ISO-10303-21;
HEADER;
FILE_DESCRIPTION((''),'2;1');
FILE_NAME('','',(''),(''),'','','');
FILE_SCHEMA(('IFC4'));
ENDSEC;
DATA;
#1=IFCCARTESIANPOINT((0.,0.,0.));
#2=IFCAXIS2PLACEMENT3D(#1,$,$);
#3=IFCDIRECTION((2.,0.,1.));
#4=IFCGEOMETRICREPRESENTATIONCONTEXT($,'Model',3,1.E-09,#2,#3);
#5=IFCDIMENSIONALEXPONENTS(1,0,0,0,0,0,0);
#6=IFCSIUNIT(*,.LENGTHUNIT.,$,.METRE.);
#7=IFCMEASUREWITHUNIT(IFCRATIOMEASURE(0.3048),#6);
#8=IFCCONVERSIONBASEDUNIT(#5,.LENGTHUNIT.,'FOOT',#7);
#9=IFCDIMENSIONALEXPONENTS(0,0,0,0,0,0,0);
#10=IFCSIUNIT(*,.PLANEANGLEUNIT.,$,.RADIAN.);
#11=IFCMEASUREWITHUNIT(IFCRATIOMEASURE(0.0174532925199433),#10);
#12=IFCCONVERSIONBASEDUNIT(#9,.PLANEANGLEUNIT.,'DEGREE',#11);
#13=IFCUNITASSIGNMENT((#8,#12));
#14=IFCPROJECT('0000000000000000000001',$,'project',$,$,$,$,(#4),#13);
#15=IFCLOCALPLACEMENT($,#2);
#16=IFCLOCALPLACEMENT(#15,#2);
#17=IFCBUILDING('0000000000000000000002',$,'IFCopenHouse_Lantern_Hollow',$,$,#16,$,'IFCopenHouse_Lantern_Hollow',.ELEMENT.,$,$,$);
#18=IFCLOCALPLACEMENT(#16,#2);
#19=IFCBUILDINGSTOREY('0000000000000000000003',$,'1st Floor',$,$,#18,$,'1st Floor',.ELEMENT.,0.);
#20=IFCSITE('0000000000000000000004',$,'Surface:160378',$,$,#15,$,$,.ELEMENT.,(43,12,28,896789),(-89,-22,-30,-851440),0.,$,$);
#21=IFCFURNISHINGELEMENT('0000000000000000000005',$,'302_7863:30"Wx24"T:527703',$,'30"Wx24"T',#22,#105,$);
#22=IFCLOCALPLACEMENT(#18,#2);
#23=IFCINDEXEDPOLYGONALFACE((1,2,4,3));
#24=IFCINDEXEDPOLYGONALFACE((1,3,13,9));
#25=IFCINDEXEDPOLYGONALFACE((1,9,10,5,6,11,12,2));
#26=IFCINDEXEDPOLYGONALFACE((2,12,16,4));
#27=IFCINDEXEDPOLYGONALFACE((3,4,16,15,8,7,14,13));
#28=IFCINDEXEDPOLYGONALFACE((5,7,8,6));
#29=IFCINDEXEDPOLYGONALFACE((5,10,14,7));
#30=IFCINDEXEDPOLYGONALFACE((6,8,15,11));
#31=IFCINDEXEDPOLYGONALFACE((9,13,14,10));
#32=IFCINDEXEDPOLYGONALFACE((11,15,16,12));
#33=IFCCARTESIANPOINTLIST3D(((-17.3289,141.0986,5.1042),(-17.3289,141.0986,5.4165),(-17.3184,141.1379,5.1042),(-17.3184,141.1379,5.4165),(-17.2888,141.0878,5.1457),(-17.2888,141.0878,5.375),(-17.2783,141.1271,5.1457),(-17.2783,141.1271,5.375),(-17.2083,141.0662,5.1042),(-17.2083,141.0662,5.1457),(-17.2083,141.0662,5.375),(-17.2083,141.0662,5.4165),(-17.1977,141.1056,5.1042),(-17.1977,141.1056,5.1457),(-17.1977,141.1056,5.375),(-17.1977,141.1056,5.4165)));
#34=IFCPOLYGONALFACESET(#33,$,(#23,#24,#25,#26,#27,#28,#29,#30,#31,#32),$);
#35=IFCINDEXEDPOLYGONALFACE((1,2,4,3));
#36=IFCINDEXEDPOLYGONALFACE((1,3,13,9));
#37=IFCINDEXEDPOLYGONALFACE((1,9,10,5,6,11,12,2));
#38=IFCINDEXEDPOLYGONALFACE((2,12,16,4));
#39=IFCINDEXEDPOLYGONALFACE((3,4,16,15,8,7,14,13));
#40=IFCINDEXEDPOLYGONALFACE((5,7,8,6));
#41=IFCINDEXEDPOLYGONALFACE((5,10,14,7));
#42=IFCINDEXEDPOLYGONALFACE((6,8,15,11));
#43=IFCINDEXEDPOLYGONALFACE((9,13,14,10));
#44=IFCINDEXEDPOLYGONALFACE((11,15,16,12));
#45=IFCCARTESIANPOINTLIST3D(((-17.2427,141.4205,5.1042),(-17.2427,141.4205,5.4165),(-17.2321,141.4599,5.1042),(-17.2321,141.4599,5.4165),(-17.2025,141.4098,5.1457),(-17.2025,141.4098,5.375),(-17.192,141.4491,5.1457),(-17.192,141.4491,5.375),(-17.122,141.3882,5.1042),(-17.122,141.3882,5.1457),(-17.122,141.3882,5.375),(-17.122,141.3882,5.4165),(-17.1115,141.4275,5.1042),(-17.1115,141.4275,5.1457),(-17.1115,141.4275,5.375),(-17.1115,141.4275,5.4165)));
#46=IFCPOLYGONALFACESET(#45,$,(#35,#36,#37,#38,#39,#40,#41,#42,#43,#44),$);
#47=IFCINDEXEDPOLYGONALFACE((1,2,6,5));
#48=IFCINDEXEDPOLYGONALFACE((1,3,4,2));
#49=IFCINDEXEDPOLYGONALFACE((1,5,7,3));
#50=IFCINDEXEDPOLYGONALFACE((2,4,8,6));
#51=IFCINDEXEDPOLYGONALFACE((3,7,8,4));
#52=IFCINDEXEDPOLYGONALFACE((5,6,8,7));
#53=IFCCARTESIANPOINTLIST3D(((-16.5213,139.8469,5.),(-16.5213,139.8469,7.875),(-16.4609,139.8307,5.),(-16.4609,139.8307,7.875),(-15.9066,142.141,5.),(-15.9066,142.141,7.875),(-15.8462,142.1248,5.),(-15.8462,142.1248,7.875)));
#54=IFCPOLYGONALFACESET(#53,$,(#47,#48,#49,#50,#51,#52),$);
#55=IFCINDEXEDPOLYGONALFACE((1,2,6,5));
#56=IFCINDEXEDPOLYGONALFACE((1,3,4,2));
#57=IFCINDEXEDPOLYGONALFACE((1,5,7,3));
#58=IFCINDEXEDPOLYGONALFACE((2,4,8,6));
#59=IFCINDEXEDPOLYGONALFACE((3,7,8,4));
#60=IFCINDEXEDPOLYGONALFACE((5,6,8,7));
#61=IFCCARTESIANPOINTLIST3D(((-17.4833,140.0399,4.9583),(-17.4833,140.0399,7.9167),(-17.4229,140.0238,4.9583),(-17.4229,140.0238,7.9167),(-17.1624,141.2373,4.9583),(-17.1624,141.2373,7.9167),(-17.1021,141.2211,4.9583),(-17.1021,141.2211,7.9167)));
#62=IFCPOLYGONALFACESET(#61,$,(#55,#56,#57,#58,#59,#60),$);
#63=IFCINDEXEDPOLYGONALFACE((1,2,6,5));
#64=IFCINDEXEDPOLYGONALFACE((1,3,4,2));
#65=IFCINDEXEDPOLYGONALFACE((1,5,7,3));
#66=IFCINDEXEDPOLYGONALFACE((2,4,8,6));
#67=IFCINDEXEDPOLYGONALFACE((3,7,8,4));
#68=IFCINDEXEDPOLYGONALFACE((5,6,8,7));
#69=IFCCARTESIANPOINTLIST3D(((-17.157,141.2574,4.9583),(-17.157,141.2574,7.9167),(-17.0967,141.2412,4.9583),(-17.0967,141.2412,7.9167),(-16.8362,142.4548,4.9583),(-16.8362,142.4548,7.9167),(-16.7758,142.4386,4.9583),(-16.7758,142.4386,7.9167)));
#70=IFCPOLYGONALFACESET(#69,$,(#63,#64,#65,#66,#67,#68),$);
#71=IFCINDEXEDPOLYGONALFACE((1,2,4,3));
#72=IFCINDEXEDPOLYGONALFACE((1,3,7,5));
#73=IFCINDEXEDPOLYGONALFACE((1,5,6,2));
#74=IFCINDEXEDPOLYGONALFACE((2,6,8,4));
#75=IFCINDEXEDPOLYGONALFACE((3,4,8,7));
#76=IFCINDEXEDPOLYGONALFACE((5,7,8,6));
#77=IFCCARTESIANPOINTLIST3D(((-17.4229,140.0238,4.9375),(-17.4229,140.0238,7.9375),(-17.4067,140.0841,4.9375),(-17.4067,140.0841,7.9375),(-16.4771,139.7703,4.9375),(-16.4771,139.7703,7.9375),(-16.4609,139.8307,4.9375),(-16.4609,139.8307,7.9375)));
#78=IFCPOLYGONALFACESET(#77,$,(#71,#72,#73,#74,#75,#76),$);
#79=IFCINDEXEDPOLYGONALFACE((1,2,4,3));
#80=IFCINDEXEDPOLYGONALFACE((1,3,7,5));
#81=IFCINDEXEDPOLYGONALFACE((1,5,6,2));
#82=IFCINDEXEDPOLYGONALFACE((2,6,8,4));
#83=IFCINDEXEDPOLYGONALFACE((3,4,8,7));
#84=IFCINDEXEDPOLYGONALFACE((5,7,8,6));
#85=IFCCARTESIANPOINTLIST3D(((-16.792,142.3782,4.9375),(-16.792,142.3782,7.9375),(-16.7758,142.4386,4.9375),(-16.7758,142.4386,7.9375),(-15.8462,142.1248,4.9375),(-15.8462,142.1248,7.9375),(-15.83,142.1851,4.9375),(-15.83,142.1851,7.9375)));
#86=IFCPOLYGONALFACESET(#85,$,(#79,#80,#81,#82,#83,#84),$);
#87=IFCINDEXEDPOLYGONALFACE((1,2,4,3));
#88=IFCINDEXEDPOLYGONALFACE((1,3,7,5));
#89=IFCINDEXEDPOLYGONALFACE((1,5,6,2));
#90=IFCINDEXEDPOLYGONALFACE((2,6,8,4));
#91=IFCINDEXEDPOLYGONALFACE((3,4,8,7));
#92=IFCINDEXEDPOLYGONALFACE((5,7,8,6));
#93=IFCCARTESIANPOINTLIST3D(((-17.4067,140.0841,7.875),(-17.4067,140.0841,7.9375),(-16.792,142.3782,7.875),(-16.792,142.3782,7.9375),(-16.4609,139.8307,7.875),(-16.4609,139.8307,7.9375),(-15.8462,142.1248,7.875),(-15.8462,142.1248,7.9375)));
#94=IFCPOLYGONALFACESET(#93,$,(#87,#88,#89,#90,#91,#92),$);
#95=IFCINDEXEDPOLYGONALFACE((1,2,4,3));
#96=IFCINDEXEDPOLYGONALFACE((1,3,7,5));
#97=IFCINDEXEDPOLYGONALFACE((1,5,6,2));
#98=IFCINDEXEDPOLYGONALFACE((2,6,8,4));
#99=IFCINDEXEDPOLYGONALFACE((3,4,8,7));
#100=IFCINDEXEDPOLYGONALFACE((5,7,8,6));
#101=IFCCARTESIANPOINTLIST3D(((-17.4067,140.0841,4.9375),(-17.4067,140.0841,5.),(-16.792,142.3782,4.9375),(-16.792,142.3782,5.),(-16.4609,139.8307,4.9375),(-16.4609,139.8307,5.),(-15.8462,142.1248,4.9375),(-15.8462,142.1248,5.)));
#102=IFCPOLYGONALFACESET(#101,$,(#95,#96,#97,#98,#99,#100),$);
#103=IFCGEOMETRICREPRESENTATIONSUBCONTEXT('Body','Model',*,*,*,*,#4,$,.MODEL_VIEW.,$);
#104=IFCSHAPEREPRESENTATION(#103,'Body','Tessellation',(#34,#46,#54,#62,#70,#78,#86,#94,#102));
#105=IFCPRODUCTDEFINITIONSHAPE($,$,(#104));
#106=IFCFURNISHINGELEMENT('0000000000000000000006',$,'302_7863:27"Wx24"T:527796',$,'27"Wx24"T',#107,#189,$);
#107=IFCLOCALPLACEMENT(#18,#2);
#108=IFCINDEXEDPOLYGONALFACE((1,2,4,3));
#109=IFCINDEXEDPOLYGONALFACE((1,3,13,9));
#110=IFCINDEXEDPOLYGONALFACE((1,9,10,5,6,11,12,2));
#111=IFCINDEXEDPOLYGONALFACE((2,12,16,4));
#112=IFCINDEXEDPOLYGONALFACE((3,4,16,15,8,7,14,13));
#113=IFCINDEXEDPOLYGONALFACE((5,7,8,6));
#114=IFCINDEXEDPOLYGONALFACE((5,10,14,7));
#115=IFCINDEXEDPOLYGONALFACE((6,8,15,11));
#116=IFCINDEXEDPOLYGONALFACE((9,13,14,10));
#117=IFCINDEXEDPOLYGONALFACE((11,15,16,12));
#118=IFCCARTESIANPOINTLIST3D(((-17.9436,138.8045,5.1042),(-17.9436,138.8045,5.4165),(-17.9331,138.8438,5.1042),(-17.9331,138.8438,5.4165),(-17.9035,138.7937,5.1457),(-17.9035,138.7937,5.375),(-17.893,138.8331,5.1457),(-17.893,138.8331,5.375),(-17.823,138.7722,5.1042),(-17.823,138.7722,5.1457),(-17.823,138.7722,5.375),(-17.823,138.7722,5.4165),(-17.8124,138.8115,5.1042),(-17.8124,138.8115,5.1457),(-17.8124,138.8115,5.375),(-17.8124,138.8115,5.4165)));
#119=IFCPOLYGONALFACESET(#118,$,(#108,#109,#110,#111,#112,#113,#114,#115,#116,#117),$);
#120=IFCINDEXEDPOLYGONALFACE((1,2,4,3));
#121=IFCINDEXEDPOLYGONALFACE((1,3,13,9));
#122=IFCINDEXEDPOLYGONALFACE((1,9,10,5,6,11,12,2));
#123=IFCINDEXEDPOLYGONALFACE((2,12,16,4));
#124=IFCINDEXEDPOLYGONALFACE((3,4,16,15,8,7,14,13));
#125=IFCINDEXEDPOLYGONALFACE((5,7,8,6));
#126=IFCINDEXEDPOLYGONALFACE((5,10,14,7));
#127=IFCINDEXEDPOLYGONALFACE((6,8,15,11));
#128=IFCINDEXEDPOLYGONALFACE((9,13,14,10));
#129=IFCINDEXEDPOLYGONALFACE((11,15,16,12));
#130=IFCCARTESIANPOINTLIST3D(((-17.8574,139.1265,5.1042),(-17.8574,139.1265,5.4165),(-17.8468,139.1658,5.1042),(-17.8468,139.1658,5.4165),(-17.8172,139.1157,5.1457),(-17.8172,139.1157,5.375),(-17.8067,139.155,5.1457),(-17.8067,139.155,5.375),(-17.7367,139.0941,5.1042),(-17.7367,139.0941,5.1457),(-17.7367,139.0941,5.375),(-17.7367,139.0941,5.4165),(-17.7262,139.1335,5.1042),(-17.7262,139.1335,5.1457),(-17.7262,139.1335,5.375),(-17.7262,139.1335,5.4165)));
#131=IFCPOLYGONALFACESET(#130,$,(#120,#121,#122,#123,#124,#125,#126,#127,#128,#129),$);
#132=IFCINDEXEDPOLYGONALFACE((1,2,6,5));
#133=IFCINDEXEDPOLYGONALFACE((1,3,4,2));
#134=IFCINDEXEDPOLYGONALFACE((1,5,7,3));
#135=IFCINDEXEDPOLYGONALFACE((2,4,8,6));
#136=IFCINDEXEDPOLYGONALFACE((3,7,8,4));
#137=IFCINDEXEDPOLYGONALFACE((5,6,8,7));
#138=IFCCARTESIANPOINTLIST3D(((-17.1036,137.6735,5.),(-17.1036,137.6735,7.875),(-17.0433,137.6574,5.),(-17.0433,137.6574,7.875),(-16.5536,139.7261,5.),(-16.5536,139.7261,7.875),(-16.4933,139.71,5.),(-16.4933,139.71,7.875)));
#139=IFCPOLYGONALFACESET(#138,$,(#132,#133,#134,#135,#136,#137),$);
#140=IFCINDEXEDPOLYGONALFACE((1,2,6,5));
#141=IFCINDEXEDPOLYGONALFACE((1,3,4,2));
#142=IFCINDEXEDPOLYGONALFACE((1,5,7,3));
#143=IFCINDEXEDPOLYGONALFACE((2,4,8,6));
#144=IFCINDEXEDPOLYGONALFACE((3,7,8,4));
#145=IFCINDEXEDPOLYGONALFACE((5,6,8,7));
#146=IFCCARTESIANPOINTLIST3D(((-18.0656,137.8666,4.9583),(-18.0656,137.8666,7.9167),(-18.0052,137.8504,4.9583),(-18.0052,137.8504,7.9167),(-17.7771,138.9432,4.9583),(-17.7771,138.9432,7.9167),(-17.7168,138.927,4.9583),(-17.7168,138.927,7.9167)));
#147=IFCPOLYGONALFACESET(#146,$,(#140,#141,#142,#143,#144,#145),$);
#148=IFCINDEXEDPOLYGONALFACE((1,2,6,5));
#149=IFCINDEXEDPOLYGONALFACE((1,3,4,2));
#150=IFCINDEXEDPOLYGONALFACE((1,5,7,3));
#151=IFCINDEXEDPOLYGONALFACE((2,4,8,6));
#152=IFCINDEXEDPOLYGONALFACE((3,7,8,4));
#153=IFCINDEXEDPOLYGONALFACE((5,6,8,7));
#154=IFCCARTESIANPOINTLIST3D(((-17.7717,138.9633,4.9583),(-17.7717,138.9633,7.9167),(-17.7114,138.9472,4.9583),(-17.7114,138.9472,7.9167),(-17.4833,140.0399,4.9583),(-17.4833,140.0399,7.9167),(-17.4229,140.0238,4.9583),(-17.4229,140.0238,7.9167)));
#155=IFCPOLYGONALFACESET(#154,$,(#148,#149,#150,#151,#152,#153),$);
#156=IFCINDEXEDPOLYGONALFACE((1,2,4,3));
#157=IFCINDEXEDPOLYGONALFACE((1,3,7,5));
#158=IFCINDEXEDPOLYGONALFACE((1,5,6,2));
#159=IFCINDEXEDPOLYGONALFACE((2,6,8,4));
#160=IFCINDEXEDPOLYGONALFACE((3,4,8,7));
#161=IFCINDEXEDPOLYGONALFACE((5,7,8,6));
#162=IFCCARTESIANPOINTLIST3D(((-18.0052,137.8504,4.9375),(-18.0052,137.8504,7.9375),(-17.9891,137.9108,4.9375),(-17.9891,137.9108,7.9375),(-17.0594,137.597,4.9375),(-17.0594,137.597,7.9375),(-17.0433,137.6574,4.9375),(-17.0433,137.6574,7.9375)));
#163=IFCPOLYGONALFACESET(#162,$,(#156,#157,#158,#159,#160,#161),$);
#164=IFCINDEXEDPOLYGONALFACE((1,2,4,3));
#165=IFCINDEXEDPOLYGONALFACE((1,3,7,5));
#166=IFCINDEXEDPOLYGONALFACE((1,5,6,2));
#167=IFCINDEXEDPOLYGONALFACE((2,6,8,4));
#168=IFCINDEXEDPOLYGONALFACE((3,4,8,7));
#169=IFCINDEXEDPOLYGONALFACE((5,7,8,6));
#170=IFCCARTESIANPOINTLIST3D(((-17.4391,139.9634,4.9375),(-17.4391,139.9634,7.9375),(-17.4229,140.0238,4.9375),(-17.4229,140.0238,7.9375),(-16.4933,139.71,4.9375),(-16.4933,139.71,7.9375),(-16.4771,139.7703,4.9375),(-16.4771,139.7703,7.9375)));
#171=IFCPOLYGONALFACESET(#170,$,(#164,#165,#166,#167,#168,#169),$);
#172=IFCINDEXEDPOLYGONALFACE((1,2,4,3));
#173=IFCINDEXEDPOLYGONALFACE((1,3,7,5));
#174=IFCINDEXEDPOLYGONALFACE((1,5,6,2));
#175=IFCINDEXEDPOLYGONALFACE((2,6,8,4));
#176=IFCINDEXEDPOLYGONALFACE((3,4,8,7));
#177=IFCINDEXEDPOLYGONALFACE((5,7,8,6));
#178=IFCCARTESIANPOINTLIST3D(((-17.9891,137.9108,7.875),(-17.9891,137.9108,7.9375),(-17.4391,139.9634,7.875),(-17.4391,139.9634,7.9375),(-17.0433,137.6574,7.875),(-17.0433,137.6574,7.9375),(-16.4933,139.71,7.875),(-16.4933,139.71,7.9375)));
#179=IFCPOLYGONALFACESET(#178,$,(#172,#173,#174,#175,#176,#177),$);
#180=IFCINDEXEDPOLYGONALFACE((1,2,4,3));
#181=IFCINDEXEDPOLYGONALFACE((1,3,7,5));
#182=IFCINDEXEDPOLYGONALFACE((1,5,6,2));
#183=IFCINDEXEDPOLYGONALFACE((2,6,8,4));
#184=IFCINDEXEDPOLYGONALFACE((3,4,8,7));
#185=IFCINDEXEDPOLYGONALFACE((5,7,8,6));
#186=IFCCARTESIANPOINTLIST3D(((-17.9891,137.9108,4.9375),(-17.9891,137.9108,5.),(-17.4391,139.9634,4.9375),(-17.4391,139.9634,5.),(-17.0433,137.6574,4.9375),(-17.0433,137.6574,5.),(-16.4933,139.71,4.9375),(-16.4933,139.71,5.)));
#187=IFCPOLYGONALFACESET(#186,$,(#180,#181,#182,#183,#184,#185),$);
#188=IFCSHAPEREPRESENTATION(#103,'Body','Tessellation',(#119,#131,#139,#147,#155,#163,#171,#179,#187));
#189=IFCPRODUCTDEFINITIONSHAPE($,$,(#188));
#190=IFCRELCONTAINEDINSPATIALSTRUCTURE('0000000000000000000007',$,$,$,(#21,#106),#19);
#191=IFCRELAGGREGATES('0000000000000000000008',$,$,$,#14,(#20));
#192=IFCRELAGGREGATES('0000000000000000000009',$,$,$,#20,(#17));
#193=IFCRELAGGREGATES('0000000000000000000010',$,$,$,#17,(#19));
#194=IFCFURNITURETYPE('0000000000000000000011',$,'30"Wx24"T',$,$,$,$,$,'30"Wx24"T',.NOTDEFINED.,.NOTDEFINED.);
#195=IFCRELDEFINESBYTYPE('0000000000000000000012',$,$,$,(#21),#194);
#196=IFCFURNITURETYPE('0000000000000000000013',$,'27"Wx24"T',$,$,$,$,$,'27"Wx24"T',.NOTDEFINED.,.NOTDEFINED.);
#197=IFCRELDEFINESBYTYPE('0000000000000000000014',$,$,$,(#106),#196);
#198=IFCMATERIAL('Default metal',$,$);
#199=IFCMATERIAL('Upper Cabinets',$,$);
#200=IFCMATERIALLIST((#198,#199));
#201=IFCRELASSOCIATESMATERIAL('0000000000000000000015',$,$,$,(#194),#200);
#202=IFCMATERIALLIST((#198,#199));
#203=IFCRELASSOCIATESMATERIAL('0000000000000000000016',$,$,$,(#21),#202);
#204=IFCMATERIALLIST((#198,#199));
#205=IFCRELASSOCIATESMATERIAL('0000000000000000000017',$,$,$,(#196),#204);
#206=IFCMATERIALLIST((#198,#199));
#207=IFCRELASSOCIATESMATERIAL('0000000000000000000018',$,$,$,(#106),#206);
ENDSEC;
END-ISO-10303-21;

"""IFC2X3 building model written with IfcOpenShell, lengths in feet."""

from ifc_helpers import new_model, entity, si_unit, converted_unit, direction, frame, frame_2d, origin, origin_2d_with_axis, place, context, subcontext, project, spatial, polyline, rectangle, outline, extrude, source, transform, mapped, material, material_list, type_object, type_shapes, element, save


model = new_model("IFC2X3")

# Units and contexts
model_context = context("Model", 3, precision=1e-09, world=origin(), true_north=direction((2.0, 0.0, 1.0)))
body_context = subcontext(model_context, "Body", "Model", "MODEL_VIEW")
ifc_project = project(units=[converted_unit("LENGTHUNIT", "FOOT", entity("IfcRatioMeasure", 0.3048), si_unit("LENGTHUNIT", "METRE"), dimensions=[1, 0, 0, 0, 0, 0, 0]), converted_unit("PLANEANGLEUNIT", "DEGREE", entity("IfcRatioMeasure", 0.0174532925199433), si_unit("PLANEANGLEUNIT", "RADIAN"), dimensions=[0, 0, 0, 0, 0, 0, 0])], contexts=[model_context])

# Site, building, storey
site_placement = place(None, origin())
site = spatial("IfcSite", under=ifc_project, at=site_placement, Name="Surface:160378", CompositionType="ELEMENT", RefLatitude=(43, 12, 28, 896789), RefLongitude=(-89, -22, -30, -851440), RefElevation=0.0)
building_placement = place(site_placement, origin())
building = spatial("IfcBuilding", under=site, at=building_placement, Name="IFCopenHouse_Lantern_Hollow", LongName="IFCopenHouse_Lantern_Hollow", CompositionType="ELEMENT")
storey_placement = place(building_placement, origin())
storey = spatial("IfcBuildingStorey", under=building, at=storey_placement, Name="1st Floor", LongName="1st Floor", CompositionType="ELEMENT", Elevation=0.0)

# Furnishing elements
ifc_material_1 = material(Name="Default metal")
ifc_material_2 = material(Name="Upper Cabinets")
ifc_material_list_1 = material_list([ifc_material_1, ifc_material_2])
ifc_material_list_2 = material_list([ifc_material_1, ifc_material_2])
furniture_type_1 = type_object("IfcFurnitureType", Name="30\"Wx24\"T", ElementType="30\"Wx24\"T", AssemblyPlace="NOTDEFINED", material=ifc_material_list_2)
shared_shape_1 = source(origin(), body_context, "Body", "SweptSolid", [
    extrude(outline(polyline([(-0.0521, -0.1146), (-0.0521, -0.1562), (0.0729, -0.1562), (0.0729, 0.1562), (-0.0521, 0.1562), (-0.0521, 0.1146), (0.0313, 0.1146), (0.0313, -0.1146), (-0.0521, -0.1146)])), frame((1.0625, 1.0937, 0.3229), z_axis=(-1.0, 0.0, 0.0), x_axis=(0.0, 1.0, 0.0)), (0.0, 0.0, -1.0), 0.0407),
    extrude(outline(polyline([(-0.0521, -0.1146), (-0.0521, -0.1562), (0.0729, -0.1562), (0.0729, 0.1562), (-0.0521, 0.1562), (-0.0521, 0.1146), (0.0313, 0.1146), (0.0313, -0.1146), (-0.0521, -0.1146)])), frame((1.3958, 1.0937, 0.3229), z_axis=(-1.0, 0.0, 0.0), x_axis=(0.0, 1.0, 0.0)), (0.0, 0.0, -1.0), 0.0407),
    extrude(rectangle(XDim=0.0625, YDim=2.375, at=frame_2d((0.0, 0.0), x_axis=(1.0, 0.0))), frame((1.25, 0.0313, 0.0625), z_axis=(0.0, 0.0, 1.0), x_axis=(0.0, 1.0, 0.0)), (0.0, 0.0, 1.0), 2.875),
    extrude(rectangle(XDim=0.0625, YDim=1.2396, at=origin_2d_with_axis()), frame((0.6198, 1.0104, 0.0208), z_axis=(0.0, 0.0, 1.0), x_axis=(0.0, 1.0, 0.0)), (0.0, 0.0, 1.0), 2.9583),
    extrude(rectangle(XDim=0.0625, YDim=1.2396, at=origin_2d_with_axis()), frame((1.8802, 1.0104, 0.0208), z_axis=(0.0, 0.0, 1.0), x_axis=(0.0, 1.0, 0.0)), (0.0, 0.0, 1.0), 2.9583),
    extrude(rectangle(XDim=0.0625, YDim=0.9792, at=frame_2d((0.0, 0.0), x_axis=(1.0, 0.0))), frame((0.0313, 0.4896, 0.0)), (0.0, 0.0, 1.0), 3.0),
    extrude(rectangle(XDim=0.0625, YDim=0.9792, at=origin_2d_with_axis()), frame((2.4688, 0.4896, 0.0)), (0.0, 0.0, 1.0), 3.0),
    extrude(rectangle(XDim=2.375, YDim=0.9792, at=origin_2d_with_axis()), frame((1.25, 0.4896, 2.9375), z_axis=(0.0, 0.0, 1.0), x_axis=(-1.0, 0.0, 0.0)), (0.0, 0.0, 1.0), 0.0625),
    extrude(rectangle(XDim=2.375, YDim=0.9792, at=frame_2d((0.0, 0.0), x_axis=(1.0, 0.0))), frame((1.25, 0.4896, 0.0), z_axis=(0.0, 0.0, 1.0), x_axis=(-1.0, 0.0, 0.0)), (0.0, 0.0, 1.0), 0.0625),
])
type_shapes(furniture_type_1, [shared_shape_1])
furnishing_1_placement = place(storey_placement, frame((-16.4771, 139.7703, 4.9375), z_axis=(0.0, 0.0, 1.0), x_axis=(0.258819, 0.965926, 0.0)))
element("IfcFurnishingElement", 1, at=furnishing_1_placement, inside=storey, type_object=furniture_type_1, material=ifc_material_list_1, Name="302_7863:30\"Wx24\"T:527703", ObjectType="30\"Wx24\"T", context=body_context, shape_type="MappedRepresentation", body=[
    mapped(shared_shape_1, transform((0.0, 0.0, 0.0), scale=1.0)),
])
ifc_material_list_3 = material_list([ifc_material_1, ifc_material_2])
ifc_material_list_4 = material_list([ifc_material_1, ifc_material_2])
furniture_type_2 = type_object("IfcFurnitureType", Name="27\"Wx24\"T", ElementType="27\"Wx24\"T", AssemblyPlace="NOTDEFINED", material=ifc_material_list_4)
shared_shape_2 = source(origin(), body_context, "Body", "SweptSolid", [
    extrude(outline(polyline([(-0.0521, -0.1146), (-0.0521, -0.1562), (0.0729, -0.1562), (0.0729, 0.1562), (-0.0521, 0.1562), (-0.0521, 0.1146), (0.0313, 0.1146), (0.0313, -0.1146), (-0.0521, -0.1146)])), frame((0.9375, 1.0937, 0.3229), z_axis=(-1.0, 0.0, 0.0), x_axis=(0.0, 1.0, 0.0)), (0.0, 0.0, -1.0), 0.0407),
    extrude(outline(polyline([(-0.0521, -0.1146), (-0.0521, -0.1562), (0.0729, -0.1562), (0.0729, 0.1562), (-0.0521, 0.1562), (-0.0521, 0.1146), (0.0313, 0.1146), (0.0313, -0.1146), (-0.0521, -0.1146)])), frame((1.2708, 1.0937, 0.3229), z_axis=(-1.0, 0.0, 0.0), x_axis=(0.0, 1.0, 0.0)), (0.0, 0.0, -1.0), 0.0407),
    extrude(rectangle(XDim=0.0625, YDim=2.125, at=frame_2d((0.0, 0.0), x_axis=(1.0, 0.0))), frame((1.125, 0.0313, 0.0625), z_axis=(0.0, 0.0, 1.0), x_axis=(0.0, 1.0, 0.0)), (0.0, 0.0, 1.0), 2.875),
    extrude(rectangle(XDim=0.0625, YDim=1.1146, at=origin_2d_with_axis()), frame((0.5573, 1.0104, 0.0208), z_axis=(0.0, 0.0, 1.0), x_axis=(0.0, 1.0, 0.0)), (0.0, 0.0, 1.0), 2.9583),
    extrude(rectangle(XDim=0.0625, YDim=1.1146, at=frame_2d((0.0, 0.0), x_axis=(1.0, 0.0))), frame((1.6927, 1.0104, 0.0208), z_axis=(0.0, 0.0, 1.0), x_axis=(0.0, 1.0, 0.0)), (0.0, 0.0, 1.0), 2.9583),
    extrude(rectangle(XDim=0.0625, YDim=0.9792, at=frame_2d((0.0, 0.0), x_axis=(1.0, 0.0))), frame((0.0313, 0.4896, 0.0)), (0.0, 0.0, 1.0), 3.0),
    extrude(rectangle(XDim=0.0625, YDim=0.9792, at=origin_2d_with_axis()), frame((2.2188, 0.4896, 0.0)), (0.0, 0.0, 1.0), 3.0),
    extrude(rectangle(XDim=2.125, YDim=0.9792, at=origin_2d_with_axis()), frame((1.125, 0.4896, 2.9375), z_axis=(0.0, 0.0, 1.0), x_axis=(-1.0, 0.0, 0.0)), (0.0, 0.0, 1.0), 0.0625),
    extrude(rectangle(XDim=2.125, YDim=0.9792, at=frame_2d((0.0, 0.0), x_axis=(1.0, 0.0))), frame((1.125, 0.4896, 0.0), z_axis=(0.0, 0.0, 1.0), x_axis=(-1.0, 0.0, 0.0)), (0.0, 0.0, 1.0), 0.0625),
])
type_shapes(furniture_type_2, [shared_shape_2])
furnishing_2_placement = place(storey_placement, frame((-17.0594, 137.597, 4.9375), z_axis=(0.0, 0.0, 1.0), x_axis=(0.258819, 0.965926, 0.0)))
element("IfcFurnishingElement", 2, at=furnishing_2_placement, inside=storey, type_object=furniture_type_2, material=ifc_material_list_3, Name="302_7863:27\"Wx24\"T:527796", ObjectType="27\"Wx24\"T", context=body_context, shape_type="MappedRepresentation", body=[
    mapped(shared_shape_2, transform((0.0, 0.0, 0.0), scale=1.0)),
])

save(model, "model.ifc")
